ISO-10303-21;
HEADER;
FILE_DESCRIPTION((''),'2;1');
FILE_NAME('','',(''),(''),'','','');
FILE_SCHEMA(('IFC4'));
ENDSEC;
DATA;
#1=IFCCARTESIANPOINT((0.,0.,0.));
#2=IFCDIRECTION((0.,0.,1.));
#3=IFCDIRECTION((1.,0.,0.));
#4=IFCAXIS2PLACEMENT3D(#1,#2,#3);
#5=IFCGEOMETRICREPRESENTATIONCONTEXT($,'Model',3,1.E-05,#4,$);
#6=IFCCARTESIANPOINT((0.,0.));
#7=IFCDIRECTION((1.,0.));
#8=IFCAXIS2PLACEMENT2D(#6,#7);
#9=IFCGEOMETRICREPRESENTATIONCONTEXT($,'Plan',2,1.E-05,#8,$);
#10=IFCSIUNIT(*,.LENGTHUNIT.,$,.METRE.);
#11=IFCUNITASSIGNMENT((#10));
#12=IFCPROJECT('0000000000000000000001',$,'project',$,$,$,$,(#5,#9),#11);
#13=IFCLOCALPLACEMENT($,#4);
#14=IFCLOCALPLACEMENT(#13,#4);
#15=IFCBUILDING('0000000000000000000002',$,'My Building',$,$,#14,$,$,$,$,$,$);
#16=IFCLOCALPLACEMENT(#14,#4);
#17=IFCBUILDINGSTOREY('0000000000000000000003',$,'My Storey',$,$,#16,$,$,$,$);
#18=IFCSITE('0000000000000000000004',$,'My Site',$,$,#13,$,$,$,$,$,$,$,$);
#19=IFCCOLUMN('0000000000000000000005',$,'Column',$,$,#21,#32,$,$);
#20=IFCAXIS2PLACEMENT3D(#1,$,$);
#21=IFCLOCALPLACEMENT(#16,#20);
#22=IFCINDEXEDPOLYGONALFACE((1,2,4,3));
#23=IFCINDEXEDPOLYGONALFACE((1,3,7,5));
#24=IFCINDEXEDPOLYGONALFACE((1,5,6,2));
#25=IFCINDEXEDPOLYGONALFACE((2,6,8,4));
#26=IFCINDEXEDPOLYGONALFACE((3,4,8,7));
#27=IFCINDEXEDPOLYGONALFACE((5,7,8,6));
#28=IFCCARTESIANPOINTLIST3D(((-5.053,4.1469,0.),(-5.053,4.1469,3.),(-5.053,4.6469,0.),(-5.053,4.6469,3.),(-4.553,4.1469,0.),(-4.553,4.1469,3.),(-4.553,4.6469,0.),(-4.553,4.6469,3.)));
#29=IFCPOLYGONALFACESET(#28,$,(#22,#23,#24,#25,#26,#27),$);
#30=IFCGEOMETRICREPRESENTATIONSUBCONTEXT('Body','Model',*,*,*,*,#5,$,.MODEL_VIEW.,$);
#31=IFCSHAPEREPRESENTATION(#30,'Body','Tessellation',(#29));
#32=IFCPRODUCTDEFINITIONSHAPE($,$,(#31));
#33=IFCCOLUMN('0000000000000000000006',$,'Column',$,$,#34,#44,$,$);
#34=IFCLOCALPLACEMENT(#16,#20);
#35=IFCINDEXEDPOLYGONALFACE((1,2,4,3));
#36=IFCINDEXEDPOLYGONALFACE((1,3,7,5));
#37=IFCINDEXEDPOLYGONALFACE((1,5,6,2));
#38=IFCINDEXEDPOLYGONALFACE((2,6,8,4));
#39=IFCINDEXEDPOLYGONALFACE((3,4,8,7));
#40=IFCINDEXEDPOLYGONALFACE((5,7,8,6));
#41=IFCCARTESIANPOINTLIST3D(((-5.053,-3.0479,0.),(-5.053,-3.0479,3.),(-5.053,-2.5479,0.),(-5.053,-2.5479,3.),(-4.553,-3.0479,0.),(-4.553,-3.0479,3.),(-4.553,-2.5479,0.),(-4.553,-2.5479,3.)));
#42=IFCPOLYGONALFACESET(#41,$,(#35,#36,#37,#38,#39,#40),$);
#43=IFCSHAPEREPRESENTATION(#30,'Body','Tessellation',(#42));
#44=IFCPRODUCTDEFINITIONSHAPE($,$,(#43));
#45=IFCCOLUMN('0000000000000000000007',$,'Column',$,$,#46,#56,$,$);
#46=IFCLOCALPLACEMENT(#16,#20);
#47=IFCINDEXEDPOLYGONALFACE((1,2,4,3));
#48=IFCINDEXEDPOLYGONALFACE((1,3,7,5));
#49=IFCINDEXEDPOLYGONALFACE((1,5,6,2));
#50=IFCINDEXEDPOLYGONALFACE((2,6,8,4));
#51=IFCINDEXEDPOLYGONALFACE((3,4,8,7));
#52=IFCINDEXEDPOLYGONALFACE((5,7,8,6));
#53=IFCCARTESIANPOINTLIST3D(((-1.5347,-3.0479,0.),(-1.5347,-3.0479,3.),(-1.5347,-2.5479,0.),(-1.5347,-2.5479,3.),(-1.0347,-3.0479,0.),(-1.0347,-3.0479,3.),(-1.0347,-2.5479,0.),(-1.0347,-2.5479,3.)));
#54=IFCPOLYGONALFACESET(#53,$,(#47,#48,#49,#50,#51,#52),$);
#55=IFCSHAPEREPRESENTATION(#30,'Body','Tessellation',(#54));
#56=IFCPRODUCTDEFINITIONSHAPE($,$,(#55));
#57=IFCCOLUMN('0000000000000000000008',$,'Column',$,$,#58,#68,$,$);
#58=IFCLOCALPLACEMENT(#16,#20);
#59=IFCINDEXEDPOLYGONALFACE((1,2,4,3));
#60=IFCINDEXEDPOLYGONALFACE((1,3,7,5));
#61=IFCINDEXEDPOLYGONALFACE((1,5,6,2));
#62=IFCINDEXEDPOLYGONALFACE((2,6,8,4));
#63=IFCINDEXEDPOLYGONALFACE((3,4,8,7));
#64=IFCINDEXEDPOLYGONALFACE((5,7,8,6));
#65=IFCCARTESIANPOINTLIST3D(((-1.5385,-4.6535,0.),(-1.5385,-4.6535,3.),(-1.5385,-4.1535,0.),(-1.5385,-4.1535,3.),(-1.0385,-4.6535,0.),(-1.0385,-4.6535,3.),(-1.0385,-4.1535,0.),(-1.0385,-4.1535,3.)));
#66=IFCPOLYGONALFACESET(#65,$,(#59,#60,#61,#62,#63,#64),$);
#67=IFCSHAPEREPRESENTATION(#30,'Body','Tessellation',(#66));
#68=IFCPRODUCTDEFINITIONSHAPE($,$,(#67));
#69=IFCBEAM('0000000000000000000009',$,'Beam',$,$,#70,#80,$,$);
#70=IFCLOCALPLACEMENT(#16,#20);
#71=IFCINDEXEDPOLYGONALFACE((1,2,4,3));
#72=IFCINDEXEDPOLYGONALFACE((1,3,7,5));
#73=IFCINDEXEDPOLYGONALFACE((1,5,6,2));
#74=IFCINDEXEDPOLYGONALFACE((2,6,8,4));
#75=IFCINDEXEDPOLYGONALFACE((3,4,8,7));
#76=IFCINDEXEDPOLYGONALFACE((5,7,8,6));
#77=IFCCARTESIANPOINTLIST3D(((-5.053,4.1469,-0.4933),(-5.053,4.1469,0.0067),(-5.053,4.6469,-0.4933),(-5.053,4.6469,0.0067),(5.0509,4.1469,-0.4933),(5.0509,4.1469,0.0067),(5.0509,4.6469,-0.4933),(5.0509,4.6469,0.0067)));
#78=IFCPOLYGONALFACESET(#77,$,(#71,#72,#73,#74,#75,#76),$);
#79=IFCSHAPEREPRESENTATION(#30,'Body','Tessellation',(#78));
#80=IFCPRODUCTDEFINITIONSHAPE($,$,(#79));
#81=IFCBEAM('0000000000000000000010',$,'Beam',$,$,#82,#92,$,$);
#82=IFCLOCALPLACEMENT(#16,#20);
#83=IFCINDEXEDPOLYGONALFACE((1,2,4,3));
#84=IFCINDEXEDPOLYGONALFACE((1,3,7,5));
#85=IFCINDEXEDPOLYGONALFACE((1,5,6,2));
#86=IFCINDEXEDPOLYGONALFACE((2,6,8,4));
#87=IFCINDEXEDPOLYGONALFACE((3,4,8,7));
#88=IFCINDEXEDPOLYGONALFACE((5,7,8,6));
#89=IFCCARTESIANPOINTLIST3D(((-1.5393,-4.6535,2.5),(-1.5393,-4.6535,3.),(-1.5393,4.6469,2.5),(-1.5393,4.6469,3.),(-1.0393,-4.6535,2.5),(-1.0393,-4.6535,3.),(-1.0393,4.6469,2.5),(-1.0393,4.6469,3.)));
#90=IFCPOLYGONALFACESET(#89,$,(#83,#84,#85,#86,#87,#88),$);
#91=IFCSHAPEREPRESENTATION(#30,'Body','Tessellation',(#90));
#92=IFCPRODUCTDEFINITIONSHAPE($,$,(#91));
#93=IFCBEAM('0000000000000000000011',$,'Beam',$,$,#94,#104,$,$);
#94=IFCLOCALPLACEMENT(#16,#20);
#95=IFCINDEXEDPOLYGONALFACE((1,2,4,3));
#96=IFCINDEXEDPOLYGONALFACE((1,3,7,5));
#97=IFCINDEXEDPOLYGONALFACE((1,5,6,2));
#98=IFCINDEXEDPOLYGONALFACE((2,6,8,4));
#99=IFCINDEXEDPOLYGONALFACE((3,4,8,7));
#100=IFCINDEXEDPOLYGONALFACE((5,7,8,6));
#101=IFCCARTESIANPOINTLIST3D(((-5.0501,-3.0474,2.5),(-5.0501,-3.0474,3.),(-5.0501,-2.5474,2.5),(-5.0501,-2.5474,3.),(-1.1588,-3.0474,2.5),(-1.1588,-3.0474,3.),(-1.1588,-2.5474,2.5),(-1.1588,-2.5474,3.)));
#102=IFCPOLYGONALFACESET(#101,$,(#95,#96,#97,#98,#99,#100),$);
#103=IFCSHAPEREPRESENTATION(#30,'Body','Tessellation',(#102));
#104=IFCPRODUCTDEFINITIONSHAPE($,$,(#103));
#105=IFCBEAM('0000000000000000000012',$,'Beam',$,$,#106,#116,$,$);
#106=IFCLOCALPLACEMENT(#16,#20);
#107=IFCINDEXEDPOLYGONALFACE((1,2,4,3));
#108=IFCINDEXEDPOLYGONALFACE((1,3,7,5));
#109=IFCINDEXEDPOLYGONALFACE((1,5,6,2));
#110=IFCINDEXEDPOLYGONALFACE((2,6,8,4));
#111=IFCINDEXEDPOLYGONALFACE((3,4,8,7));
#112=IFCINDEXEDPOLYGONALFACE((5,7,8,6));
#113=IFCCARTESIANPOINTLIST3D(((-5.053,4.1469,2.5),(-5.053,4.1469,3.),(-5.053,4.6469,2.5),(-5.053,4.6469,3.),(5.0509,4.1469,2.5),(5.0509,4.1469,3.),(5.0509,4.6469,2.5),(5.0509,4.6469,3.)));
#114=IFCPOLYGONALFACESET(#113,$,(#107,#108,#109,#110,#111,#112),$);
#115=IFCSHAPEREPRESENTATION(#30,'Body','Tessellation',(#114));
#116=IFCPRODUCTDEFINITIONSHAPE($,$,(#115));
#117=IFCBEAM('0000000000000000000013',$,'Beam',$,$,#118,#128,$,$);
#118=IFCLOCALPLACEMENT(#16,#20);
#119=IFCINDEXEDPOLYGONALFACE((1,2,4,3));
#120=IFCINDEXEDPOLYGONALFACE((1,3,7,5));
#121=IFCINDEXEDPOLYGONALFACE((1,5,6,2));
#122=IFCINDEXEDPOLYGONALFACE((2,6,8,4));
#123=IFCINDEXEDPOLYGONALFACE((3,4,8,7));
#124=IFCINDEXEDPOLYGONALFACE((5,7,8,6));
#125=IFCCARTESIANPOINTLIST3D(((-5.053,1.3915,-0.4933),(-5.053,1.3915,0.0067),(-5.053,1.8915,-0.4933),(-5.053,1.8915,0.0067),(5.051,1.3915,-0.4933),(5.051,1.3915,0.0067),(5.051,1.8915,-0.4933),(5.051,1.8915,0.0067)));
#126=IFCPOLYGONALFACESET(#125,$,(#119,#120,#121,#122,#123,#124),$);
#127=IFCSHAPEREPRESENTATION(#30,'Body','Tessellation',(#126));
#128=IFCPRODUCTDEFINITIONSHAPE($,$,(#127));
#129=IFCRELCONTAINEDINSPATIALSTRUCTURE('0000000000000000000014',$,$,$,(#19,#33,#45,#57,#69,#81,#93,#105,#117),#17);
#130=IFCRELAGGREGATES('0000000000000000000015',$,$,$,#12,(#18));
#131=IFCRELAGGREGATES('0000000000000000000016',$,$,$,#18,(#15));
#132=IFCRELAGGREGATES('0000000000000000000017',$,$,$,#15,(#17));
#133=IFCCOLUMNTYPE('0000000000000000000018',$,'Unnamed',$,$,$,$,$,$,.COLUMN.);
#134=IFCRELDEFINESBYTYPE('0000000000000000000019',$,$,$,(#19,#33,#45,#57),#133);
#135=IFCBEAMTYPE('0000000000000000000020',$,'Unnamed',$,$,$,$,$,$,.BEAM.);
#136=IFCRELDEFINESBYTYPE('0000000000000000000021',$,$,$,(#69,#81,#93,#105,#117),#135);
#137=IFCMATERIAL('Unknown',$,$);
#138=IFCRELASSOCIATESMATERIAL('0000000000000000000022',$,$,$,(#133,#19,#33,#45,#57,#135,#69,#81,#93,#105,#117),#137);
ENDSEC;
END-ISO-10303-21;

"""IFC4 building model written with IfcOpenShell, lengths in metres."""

from ifc_helpers import new_model, si_unit, frame, origin_with_axes, origin_2d_with_axis, place, context, subcontext, project, spatial, rectangle, extrude, material, material_profile, profile_set, profile_usage, type_object, element, save


model = new_model("IFC4")

# Units and contexts
model_context = context("Model", 3, precision=1e-05, world=origin_with_axes())
plan_context = context("Plan", 2, precision=1e-05, world=origin_2d_with_axis())
body_context_1 = subcontext(model_context, "Body", "Model", "MODEL_VIEW")
ifc_project = project(units=[si_unit("LENGTHUNIT", "METRE")], contexts=[model_context, plan_context])

# Site, building, storey
site_placement = place(None, origin_with_axes())
site = spatial("IfcSite", under=ifc_project, at=site_placement, Name="My Site")
building_placement = place(site_placement, origin_with_axes())
building = spatial("IfcBuilding", under=site, at=building_placement, Name="My Building")
storey_placement = place(building_placement, origin_with_axes())
storey = spatial("IfcBuildingStorey", under=building, at=storey_placement, Name="My Storey")

# Columns
ifc_material = material(Name="Unknown")
ifc_material_profile_1 = material_profile(ifc_material, rectangle(XDim=0.5, YDim=0.5))
ifc_profile_set_1 = profile_set([ifc_material_profile_1])
ifc_profile_usage_1 = profile_usage(ifc_profile_set_1, cardinal=5)
column_type = type_object("IfcColumnType", Name="Unnamed", PredefinedType="COLUMN", material=ifc_profile_set_1)
column_1_placement = place(storey_placement, frame((-4.803, 4.3969, 0.0), z_axis=(0.0, 0.0, 1.0), x_axis=(1.0, 0.0, 0.0)))
element("IfcColumn", 1, at=column_1_placement, inside=storey, type_object=column_type, material=ifc_profile_usage_1, Name="Column", context=body_context_1, shape_type="SweptSolid", body=[
    extrude(rectangle(XDim=0.5, YDim=0.5), origin_with_axes(), (0.0, 0.0, 1.0), 3.0),
])
ifc_profile_usage_2 = profile_usage(ifc_profile_set_1, cardinal=5)
column_2_placement = place(storey_placement, frame((-4.803, -2.7979, 0.0), z_axis=(0.0, 0.0, 1.0), x_axis=(1.0, 0.0, 0.0)))
element("IfcColumn", 2, at=column_2_placement, inside=storey, type_object=column_type, material=ifc_profile_usage_2, Name="Column", context=body_context_1, shape_type="SweptSolid", body=[
    extrude(rectangle(XDim=0.5, YDim=0.5), origin_with_axes(), (0.0, 0.0, 1.0), 3.0),
])
ifc_profile_usage_3 = profile_usage(ifc_profile_set_1, cardinal=5)
column_3_placement = place(storey_placement, frame((-1.2847, -2.7979, 0.0), z_axis=(0.0, 0.0, 1.0), x_axis=(1.0, 0.0, 0.0)))
element("IfcColumn", 3, at=column_3_placement, inside=storey, type_object=column_type, material=ifc_profile_usage_3, Name="Column", context=body_context_1, shape_type="SweptSolid", body=[
    extrude(rectangle(XDim=0.5, YDim=0.5), origin_with_axes(), (0.0, 0.0, 1.0), 3.0),
])
ifc_profile_usage_4 = profile_usage(ifc_profile_set_1, cardinal=5)
column_4_placement = place(storey_placement, frame((-1.2885, -4.4035, 0.0), z_axis=(0.0, 0.0, 1.0), x_axis=(1.0, 0.0, 0.0)))
element("IfcColumn", 4, at=column_4_placement, inside=storey, type_object=column_type, material=ifc_profile_usage_4, Name="Column", context=body_context_1, shape_type="SweptSolid", body=[
    extrude(rectangle(XDim=0.5, YDim=0.5), origin_with_axes(), (0.0, 0.0, 1.0), 3.0),
])

# Beams
ifc_material_profile_2 = material_profile(ifc_material, rectangle(XDim=0.5, YDim=0.5))
ifc_profile_set_2 = profile_set([ifc_material_profile_2])
ifc_profile_usage_5 = profile_usage(ifc_profile_set_2, cardinal=5)
beam_type = type_object("IfcBeamType", Name="Unnamed", PredefinedType="BEAM", material=ifc_profile_set_2)
beam_1_placement = place(storey_placement, frame((-5.053, 4.3969, -0.2433), z_axis=(1.0, 0.0, 0.0), x_axis=(0.0, 1.0, 0.0)))
element("IfcBeam", 5, at=beam_1_placement, inside=storey, type_object=beam_type, material=ifc_profile_usage_5, Name="Beam", context=body_context_1, shape_type="SweptSolid", body=[
    extrude(rectangle(XDim=0.5, YDim=0.5), origin_with_axes(), (0.0, 0.0, 1.0), 10.1039),
])
ifc_profile_usage_6 = profile_usage(ifc_profile_set_2, cardinal=5)
beam_2_placement = place(storey_placement, frame((-1.2893, 4.6469, 2.75), z_axis=(0.0, -1.0, 0.0), x_axis=(1.0, 0.0, 0.0)))
element("IfcBeam", 6, at=beam_2_placement, inside=storey, type_object=beam_type, material=ifc_profile_usage_6, Name="Beam", context=body_context_1, shape_type="SweptSolid", body=[
    extrude(rectangle(XDim=0.5, YDim=0.5), origin_with_axes(), (0.0, 0.0, 1.0), 9.3004),
])
ifc_profile_usage_7 = profile_usage(ifc_profile_set_2, cardinal=5)
beam_3_placement = place(storey_placement, frame((-5.0501, -2.7974, 2.75), z_axis=(1.0, 0.0, 0.0), x_axis=(0.0, 1.0, 0.0)))
element("IfcBeam", 7, at=beam_3_placement, inside=storey, type_object=beam_type, material=ifc_profile_usage_7, Name="Beam", context=body_context_1, shape_type="SweptSolid", body=[
    extrude(rectangle(XDim=0.5, YDim=0.5), origin_with_axes(), (0.0, 0.0, 1.0), 3.8912),
])
ifc_profile_usage_8 = profile_usage(ifc_profile_set_2, cardinal=5)
beam_4_placement = place(storey_placement, frame((-5.053, 4.3969, 2.75), z_axis=(1.0, 0.0, 0.0), x_axis=(0.0, 1.0, 0.0)))
element("IfcBeam", 8, at=beam_4_placement, inside=storey, type_object=beam_type, material=ifc_profile_usage_8, Name="Beam", context=body_context_1, shape_type="SweptSolid", body=[
    extrude(rectangle(XDim=0.5, YDim=0.5), origin_with_axes(), (0.0, 0.0, 1.0), 10.1039),
])
ifc_profile_usage_9 = profile_usage(ifc_profile_set_2, cardinal=5)
beam_5_placement = place(storey_placement, frame((-5.053, 1.6415, -0.2433), z_axis=(1.0, 0.0, 0.000001), x_axis=(0.0, 1.0, 0.0)))
element("IfcBeam", 9, at=beam_5_placement, inside=storey, type_object=beam_type, material=ifc_profile_usage_9, Name="Beam", context=body_context_1, shape_type="SweptSolid", body=[
    extrude(rectangle(XDim=0.5, YDim=0.5), origin_with_axes(), (0.0, 0.0, 1.0), 10.1041),
])

save(model, "model.ifc")
